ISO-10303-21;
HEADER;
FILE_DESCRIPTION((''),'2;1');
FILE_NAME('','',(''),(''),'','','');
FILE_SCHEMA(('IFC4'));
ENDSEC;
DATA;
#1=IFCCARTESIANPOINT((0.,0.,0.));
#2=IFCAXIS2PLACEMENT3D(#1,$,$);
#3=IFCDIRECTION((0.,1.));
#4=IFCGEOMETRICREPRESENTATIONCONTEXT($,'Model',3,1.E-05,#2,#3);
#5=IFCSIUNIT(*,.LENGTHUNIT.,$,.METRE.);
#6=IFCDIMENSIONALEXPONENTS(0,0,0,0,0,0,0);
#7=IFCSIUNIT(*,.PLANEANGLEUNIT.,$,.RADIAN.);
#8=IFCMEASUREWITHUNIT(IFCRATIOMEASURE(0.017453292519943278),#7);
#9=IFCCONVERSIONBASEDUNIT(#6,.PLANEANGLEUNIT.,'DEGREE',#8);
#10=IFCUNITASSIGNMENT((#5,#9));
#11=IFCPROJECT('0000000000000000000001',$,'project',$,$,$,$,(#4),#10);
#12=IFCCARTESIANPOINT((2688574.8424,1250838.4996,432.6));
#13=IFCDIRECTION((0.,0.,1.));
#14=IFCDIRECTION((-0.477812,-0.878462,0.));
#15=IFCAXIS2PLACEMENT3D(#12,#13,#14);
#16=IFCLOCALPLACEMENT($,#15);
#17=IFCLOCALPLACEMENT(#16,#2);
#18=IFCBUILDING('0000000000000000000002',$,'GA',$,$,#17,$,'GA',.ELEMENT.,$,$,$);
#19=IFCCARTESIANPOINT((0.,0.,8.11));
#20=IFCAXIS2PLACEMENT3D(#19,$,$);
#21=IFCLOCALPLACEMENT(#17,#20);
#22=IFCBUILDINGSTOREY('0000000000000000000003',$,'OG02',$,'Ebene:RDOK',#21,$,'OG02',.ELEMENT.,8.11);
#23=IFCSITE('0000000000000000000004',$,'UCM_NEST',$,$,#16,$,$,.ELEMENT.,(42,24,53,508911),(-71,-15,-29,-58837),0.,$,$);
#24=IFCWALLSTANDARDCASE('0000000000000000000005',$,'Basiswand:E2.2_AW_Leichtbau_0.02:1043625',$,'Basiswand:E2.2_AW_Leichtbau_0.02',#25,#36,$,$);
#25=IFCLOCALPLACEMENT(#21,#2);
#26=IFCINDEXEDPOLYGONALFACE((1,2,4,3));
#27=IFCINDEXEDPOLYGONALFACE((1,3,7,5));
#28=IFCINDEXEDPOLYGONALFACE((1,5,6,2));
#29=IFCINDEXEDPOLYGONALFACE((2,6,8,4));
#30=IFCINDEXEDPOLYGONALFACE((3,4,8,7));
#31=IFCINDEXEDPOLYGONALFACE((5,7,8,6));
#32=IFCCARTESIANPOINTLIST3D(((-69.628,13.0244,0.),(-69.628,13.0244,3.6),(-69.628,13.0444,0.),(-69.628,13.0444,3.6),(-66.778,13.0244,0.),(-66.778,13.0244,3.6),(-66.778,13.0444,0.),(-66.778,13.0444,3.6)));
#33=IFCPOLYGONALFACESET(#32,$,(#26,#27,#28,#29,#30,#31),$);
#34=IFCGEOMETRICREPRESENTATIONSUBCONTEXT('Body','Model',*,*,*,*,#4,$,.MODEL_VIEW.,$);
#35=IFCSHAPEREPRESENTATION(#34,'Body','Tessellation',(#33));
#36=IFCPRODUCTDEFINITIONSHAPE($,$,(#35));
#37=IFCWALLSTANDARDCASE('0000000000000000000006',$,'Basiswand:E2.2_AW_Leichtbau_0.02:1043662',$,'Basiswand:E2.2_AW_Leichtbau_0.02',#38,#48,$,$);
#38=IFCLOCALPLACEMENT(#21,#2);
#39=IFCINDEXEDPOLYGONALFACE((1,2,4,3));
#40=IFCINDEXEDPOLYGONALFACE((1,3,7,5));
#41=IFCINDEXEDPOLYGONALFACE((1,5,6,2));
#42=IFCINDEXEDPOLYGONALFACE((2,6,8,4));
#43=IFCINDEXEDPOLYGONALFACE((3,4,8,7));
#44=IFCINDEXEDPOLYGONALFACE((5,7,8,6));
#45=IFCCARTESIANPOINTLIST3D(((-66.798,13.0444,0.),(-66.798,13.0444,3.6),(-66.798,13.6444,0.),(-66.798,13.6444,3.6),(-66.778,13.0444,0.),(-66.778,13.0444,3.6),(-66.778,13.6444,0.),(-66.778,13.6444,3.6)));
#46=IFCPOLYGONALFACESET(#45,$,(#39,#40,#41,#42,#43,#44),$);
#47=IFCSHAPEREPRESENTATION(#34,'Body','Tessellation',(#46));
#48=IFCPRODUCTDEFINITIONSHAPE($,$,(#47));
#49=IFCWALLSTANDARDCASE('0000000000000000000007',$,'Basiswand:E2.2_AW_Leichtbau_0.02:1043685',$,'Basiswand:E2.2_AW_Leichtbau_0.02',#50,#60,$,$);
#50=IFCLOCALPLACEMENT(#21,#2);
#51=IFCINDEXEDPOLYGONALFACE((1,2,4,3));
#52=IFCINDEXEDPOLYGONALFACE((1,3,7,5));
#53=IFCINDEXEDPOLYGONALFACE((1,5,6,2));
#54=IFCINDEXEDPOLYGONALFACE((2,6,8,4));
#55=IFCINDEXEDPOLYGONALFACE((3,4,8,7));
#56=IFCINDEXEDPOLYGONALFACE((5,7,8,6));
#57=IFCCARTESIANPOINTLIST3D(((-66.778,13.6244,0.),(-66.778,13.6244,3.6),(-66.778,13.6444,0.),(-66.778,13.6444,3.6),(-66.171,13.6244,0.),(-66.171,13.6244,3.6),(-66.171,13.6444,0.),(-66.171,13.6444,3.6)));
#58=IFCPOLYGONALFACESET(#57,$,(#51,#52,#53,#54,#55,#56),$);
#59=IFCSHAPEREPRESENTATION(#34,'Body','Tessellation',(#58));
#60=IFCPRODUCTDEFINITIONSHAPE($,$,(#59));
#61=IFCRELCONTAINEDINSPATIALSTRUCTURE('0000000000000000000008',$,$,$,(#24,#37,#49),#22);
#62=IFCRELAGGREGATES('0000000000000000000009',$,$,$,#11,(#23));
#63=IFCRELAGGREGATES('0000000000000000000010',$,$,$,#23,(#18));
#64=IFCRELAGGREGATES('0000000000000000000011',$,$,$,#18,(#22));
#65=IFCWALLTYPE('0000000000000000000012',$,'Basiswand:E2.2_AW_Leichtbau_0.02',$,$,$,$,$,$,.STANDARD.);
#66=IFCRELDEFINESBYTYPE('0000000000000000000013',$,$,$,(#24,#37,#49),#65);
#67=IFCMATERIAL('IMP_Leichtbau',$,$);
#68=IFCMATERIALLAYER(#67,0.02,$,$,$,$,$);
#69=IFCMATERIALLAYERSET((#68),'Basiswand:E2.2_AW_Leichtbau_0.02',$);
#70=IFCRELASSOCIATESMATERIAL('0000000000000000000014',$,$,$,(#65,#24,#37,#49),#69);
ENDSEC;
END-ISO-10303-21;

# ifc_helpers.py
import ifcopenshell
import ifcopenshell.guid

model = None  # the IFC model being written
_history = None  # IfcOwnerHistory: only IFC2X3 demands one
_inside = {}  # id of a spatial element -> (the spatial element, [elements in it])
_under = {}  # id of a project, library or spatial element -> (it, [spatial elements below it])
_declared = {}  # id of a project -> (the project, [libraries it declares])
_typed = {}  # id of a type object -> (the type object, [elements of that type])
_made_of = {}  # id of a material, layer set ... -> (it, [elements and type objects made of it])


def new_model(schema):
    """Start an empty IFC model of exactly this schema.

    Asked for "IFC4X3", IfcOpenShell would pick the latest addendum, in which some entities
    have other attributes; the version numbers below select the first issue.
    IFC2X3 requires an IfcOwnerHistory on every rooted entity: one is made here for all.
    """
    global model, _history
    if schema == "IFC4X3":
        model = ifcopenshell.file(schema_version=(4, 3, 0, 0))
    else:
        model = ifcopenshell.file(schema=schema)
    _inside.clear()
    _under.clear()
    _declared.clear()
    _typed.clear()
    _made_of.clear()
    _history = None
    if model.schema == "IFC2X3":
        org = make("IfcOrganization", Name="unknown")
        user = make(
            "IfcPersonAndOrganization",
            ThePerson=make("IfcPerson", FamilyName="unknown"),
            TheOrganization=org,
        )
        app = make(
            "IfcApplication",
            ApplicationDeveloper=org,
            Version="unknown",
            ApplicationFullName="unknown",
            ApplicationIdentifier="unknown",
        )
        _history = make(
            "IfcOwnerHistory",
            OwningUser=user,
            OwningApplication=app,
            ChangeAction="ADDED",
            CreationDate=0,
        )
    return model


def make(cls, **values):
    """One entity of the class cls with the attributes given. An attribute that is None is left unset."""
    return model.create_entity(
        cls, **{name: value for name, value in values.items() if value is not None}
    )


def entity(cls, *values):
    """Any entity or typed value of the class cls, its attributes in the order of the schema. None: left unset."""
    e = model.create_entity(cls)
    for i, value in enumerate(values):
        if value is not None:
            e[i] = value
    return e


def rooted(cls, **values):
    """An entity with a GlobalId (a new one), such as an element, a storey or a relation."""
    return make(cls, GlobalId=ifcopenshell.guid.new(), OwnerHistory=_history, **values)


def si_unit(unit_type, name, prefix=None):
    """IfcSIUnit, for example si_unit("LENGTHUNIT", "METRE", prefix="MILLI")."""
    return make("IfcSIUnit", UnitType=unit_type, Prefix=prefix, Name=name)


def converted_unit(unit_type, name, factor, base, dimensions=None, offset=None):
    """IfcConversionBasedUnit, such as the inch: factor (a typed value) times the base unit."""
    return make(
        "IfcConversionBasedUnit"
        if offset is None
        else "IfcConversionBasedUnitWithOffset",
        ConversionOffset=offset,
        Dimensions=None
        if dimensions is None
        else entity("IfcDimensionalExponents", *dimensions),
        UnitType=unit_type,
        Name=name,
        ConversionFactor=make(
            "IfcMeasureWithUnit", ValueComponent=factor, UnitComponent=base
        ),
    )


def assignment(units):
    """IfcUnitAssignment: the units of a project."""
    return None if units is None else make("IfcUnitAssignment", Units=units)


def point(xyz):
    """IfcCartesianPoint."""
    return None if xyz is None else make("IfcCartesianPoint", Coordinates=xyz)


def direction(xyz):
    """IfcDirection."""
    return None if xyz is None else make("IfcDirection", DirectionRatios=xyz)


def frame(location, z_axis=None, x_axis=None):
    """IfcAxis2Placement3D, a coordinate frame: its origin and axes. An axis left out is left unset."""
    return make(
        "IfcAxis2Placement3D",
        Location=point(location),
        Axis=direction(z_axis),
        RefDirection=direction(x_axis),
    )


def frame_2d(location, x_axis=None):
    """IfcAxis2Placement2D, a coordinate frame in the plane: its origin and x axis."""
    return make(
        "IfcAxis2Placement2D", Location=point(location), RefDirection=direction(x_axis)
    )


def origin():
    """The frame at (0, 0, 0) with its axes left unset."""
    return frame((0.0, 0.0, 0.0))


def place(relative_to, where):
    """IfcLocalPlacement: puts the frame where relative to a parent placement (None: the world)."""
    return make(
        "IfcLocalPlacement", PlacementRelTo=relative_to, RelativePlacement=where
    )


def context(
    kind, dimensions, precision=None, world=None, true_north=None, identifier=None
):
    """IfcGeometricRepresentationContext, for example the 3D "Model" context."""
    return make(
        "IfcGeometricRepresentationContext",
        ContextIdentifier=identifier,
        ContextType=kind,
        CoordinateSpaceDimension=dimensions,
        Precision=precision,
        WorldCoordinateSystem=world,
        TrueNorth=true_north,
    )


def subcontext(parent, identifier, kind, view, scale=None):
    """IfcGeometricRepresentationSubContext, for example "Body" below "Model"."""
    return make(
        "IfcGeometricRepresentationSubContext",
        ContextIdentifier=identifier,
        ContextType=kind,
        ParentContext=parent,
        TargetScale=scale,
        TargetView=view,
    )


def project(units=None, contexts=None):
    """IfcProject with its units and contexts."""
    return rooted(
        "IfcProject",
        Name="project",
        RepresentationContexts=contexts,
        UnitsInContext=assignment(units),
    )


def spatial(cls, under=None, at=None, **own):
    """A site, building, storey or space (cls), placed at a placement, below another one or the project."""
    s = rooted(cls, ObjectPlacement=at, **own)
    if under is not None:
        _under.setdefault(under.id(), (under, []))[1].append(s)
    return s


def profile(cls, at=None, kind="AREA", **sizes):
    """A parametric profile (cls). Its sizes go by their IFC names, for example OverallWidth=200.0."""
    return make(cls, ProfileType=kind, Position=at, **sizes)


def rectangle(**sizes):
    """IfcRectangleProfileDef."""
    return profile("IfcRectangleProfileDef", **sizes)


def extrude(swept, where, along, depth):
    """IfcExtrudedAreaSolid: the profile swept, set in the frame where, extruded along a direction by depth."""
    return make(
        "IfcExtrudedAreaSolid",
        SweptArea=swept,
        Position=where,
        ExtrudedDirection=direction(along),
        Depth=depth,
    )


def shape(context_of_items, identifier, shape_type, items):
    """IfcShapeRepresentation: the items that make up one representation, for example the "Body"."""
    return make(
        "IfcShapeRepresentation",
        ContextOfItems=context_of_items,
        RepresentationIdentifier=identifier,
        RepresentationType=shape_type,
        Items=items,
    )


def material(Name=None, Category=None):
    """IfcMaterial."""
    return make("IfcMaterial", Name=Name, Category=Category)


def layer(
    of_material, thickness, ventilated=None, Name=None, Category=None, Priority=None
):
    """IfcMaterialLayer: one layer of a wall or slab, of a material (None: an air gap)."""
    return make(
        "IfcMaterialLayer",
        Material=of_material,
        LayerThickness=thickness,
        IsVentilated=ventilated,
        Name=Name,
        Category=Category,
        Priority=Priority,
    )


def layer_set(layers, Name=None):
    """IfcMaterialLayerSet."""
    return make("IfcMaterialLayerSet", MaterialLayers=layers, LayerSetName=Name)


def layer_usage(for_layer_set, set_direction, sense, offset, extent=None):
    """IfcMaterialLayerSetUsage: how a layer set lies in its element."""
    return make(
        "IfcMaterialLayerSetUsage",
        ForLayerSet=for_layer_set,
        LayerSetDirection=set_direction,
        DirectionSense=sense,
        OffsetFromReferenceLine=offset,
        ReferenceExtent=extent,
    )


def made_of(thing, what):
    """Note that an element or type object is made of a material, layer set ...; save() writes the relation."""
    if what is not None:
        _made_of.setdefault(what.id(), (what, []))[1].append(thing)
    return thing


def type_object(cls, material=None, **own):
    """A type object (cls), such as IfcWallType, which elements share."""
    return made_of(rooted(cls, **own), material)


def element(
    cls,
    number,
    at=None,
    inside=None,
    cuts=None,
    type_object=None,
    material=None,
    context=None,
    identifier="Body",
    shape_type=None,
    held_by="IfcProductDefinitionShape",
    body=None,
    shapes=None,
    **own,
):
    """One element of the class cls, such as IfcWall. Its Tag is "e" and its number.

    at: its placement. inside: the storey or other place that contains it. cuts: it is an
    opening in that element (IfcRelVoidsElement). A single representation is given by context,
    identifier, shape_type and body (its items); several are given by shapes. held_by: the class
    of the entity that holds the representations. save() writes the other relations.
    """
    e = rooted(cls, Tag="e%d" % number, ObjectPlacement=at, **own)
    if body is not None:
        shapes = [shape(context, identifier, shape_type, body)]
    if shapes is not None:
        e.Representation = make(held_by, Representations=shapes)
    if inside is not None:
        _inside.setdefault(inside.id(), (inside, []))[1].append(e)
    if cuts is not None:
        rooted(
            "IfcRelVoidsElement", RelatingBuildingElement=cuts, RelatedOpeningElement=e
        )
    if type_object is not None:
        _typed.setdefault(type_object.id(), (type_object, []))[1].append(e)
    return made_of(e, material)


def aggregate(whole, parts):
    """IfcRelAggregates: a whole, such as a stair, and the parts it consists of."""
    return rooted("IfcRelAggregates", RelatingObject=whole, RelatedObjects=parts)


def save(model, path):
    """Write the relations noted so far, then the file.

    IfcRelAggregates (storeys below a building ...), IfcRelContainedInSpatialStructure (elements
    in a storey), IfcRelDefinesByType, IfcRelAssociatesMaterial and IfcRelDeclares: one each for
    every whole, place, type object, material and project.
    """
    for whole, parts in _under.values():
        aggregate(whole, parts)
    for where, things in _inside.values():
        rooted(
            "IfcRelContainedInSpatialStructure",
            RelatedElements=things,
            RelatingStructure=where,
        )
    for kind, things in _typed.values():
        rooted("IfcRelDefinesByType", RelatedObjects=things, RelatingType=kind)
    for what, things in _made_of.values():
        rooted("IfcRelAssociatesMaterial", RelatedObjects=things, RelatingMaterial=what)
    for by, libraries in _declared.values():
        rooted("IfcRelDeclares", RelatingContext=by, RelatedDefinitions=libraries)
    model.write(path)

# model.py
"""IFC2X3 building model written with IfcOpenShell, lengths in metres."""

from ifc_helpers import new_model, entity, si_unit, converted_unit, direction, frame, frame_2d, origin, place, context, subcontext, project, spatial, rectangle, extrude, material, layer, layer_set, layer_usage, type_object, element, save


model = new_model("IFC2X3")

# Units and contexts
model_context = context("Model", 3, precision=1e-05, world=origin(), true_north=direction((0.0, 1.0)))
body_context = subcontext(model_context, "Body", "Model", "MODEL_VIEW")
ifc_project = project(units=[si_unit("LENGTHUNIT", "METRE"), converted_unit("PLANEANGLEUNIT", "DEGREE", entity("IfcRatioMeasure", 0.017453292519943278), si_unit("PLANEANGLEUNIT", "RADIAN"), dimensions=[0, 0, 0, 0, 0, 0, 0])], contexts=[model_context])

# Site, building, storey
site_placement = place(None, frame((2688574.8424, 1250838.4996, 432.6), z_axis=(0.0, 0.0, 1.0), x_axis=(-0.477812, -0.878462, 0.0)))
site = spatial("IfcSite", under=ifc_project, at=site_placement, Name="UCM_NEST", CompositionType="ELEMENT", RefLatitude=(42, 24, 53, 508911), RefLongitude=(-71, -15, -29, -58837), RefElevation=0.0)
building_placement = place(site_placement, origin())
building = spatial("IfcBuilding", under=site, at=building_placement, Name="GA", LongName="GA", CompositionType="ELEMENT")
storey_placement = place(building_placement, frame((0.0, 0.0, 8.11)))
storey = spatial("IfcBuildingStorey", under=building, at=storey_placement, Name="OG02", ObjectType="Ebene:RDOK", LongName="OG02", CompositionType="ELEMENT", Elevation=8.11)

# Shared definitions
ifc_material_1 = material(Name="IMP_Leichtbau")

# Walls
ifc_layer_1 = layer(ifc_material_1, 0.02)
ifc_layer_set_1 = layer_set([ifc_layer_1], Name="Basiswand:E2.2_AW_Leichtbau_0.02")
ifc_layer_usage_1 = layer_usage(ifc_layer_set_1, "AXIS2", "NEGATIVE", 0.01)
wall_type_1 = type_object("IfcWallType", Name="Basiswand:E2.2_AW_Leichtbau_0.02", PredefinedType="STANDARD", material=ifc_layer_set_1)
wall_1_placement = place(storey_placement, frame((-69.628, 13.0344, 0.0)))
element("IfcWallStandardCase", 1, at=wall_1_placement, inside=storey, type_object=wall_type_1, material=ifc_layer_usage_1, Name="Basiswand:E2.2_AW_Leichtbau_0.02:1043625", ObjectType="Basiswand:E2.2_AW_Leichtbau_0.02", context=body_context, shape_type="SweptSolid", body=[
    extrude(rectangle(XDim=2.85, YDim=0.02, at=frame_2d((1.425, 0.0), x_axis=(-1.0, 0.0))), origin(), (0.0, 0.0, 1.0), 3.6),
])
wall_2_placement = place(storey_placement, frame((-66.788, 13.0444, 0.0), z_axis=(0.0, 0.0, 1.0), x_axis=(0.0, 1.0, 0.0)))
element("IfcWallStandardCase", 2, at=wall_2_placement, inside=storey, type_object=wall_type_1, material=ifc_layer_usage_1, Name="Basiswand:E2.2_AW_Leichtbau_0.02:1043662", ObjectType="Basiswand:E2.2_AW_Leichtbau_0.02", context=body_context, shape_type="SweptSolid", body=[
    extrude(rectangle(XDim=0.6, YDim=0.02, at=frame_2d((0.3, 0.0), x_axis=(-1.0, 0.0))), origin(), (0.0, 0.0, 1.0), 3.6),
])
wall_3_placement = place(storey_placement, frame((-66.778, 13.6344, 0.0)))
element("IfcWallStandardCase", 3, at=wall_3_placement, inside=storey, type_object=wall_type_1, material=ifc_layer_usage_1, Name="Basiswand:E2.2_AW_Leichtbau_0.02:1043685", ObjectType="Basiswand:E2.2_AW_Leichtbau_0.02", context=body_context, shape_type="SweptSolid", body=[
    extrude(rectangle(XDim=0.607, YDim=0.02, at=frame_2d((0.3035, 0.0), x_axis=(-1.0, 0.0))), origin(), (0.0, 0.0, 1.0), 3.6),
])

save(model, "model.ifc")
